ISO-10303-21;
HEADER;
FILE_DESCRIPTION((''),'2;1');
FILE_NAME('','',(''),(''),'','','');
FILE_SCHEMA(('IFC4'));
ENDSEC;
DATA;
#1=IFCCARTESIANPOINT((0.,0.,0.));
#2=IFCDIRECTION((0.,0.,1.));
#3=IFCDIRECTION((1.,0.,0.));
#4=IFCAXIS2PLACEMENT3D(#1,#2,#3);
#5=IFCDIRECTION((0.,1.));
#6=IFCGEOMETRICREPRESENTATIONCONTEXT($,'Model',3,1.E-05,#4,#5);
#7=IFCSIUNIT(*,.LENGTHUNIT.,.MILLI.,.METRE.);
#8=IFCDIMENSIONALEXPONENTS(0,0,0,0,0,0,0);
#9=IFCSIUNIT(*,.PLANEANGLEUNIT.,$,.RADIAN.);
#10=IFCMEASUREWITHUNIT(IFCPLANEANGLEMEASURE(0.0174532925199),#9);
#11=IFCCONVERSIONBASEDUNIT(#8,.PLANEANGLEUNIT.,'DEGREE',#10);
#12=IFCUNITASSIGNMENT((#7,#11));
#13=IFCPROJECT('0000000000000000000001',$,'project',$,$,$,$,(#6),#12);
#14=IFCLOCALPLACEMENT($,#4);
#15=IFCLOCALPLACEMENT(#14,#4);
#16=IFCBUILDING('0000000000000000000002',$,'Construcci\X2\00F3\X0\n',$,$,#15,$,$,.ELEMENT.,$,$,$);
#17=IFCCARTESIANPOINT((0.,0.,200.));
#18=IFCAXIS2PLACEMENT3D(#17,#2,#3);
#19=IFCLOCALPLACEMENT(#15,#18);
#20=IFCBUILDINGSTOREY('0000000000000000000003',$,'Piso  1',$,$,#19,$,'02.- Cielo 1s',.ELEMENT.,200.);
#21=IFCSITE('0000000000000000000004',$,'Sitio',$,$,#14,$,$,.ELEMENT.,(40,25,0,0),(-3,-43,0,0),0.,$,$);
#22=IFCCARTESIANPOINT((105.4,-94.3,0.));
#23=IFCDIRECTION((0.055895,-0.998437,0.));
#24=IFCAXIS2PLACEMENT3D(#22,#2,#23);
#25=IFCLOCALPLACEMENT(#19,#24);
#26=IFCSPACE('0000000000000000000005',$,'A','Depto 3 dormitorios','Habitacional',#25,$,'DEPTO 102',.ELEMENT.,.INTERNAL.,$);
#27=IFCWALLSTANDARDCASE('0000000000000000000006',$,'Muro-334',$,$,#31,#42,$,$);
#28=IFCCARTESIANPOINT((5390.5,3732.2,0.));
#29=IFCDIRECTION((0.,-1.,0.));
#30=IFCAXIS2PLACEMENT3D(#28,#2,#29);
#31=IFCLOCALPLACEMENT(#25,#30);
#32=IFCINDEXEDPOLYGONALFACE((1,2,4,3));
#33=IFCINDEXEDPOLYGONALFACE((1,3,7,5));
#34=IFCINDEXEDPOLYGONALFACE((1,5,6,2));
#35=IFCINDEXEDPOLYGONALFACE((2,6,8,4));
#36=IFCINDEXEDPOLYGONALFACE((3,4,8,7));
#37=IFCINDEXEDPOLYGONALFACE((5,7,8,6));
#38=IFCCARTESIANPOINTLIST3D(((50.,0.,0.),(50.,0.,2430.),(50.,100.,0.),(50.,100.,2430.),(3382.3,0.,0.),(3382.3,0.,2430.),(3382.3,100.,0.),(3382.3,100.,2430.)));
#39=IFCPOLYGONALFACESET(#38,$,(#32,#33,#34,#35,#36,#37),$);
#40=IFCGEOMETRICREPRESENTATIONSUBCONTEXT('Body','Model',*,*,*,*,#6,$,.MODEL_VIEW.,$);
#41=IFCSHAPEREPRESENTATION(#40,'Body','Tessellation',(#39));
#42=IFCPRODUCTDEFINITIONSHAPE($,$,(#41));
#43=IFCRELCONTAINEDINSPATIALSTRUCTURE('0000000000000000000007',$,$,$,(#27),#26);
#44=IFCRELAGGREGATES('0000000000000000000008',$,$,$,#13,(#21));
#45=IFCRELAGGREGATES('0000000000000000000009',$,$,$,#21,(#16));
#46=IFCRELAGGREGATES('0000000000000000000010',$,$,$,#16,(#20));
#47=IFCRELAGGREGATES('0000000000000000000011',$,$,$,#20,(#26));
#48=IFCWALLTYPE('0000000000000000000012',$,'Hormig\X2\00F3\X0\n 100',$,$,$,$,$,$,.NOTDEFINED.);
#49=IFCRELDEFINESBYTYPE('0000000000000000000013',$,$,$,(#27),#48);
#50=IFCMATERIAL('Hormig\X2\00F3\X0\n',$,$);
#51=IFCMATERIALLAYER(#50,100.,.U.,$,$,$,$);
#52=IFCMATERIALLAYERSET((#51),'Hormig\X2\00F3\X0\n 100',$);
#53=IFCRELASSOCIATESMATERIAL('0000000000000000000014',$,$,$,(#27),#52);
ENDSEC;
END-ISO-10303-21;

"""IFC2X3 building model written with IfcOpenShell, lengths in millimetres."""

from ifc_helpers import new_model, entity, si_unit, converted_unit, direction, frame, origin_with_axes, place, context, subcontext, project, spatial, polyline, outline, extrude, material, layer, layer_set, layer_usage, type_object, element, save


model = new_model("IFC2X3")

# Units and contexts
model_context = context("Model", 3, precision=1e-05, world=origin_with_axes(), true_north=direction((0.0, 1.0)))
body_context = subcontext(model_context, "Body", "Model", "MODEL_VIEW")
ifc_project = project(units=[si_unit("LENGTHUNIT", "METRE", prefix="MILLI"), converted_unit("PLANEANGLEUNIT", "DEGREE", entity("IfcPlaneAngleMeasure", 0.0174532925199), si_unit("PLANEANGLEUNIT", "RADIAN"), dimensions=[0, 0, 0, 0, 0, 0, 0])], contexts=[model_context])

# Site, building, storey
site_placement = place(None, origin_with_axes())
site = spatial("IfcSite", under=ifc_project, at=site_placement, Name="Sitio", CompositionType="ELEMENT", RefLatitude=(40, 25, 0, 0), RefLongitude=(-3, -43, 0, 0), RefElevation=0.0)
building_placement = place(site_placement, origin_with_axes())
building = spatial("IfcBuilding", under=site, at=building_placement, Name="Construcción", CompositionType="ELEMENT")
storey_placement = place(building_placement, frame((0.0, 0.0, 200.0), z_axis=(0.0, 0.0, 1.0), x_axis=(1.0, 0.0, 0.0)))
storey = spatial("IfcBuildingStorey", under=building, at=storey_placement, Name="Piso  1", LongName="02.- Cielo 1s", CompositionType="ELEMENT", Elevation=200.0)

# Shared definitions
ifc_material = material(Name="Hormigón")

# Shared definitions
space_placement = place(storey_placement, frame((105.4, -94.3, 0.0), z_axis=(0.0, 0.0, 1.0), x_axis=(0.055895, -0.998437, 0.0)))
space = spatial("IfcSpace", under=storey, at=space_placement, Name="A", Description="Depto 3 dormitorios", ObjectType="Habitacional", LongName="DEPTO 102", CompositionType="ELEMENT", InteriorOrExteriorSpace="INTERNAL")

# Wall
ifc_layer_1 = layer(ifc_material, 100.0, ventilated="UNKNOWN")
ifc_layer_set_1 = layer_set([ifc_layer_1], Name="Hormigón 100")
ifc_layer_usage_1 = layer_usage(ifc_layer_set_1, "AXIS2", "NEGATIVE", 100.0)
wall_type_1 = type_object("IfcWallType", Name="Hormigón 100", PredefinedType="NOTDEFINED")
wall_1_placement = place(space_placement, frame((5390.5, 3732.2, 0.0), z_axis=(0.0, 0.0, 1.0), x_axis=(0.0, -1.0, 0.0)))
element("IfcWallStandardCase", 1, at=wall_1_placement, inside=space, type_object=wall_type_1, material=ifc_layer_usage_1, Name="Muro-334", context=body_context, shape_type="SweptSolid", body=[
    extrude(outline(polyline([(50.0, 0.0), (3382.3, 0.0), (3382.3, 100.0), (50.0, 100.0), (50.0, 0.0)])), origin_with_axes(), (0.0, 0.0, 1.0), 2430.0),
])

save(model, "model.ifc")
